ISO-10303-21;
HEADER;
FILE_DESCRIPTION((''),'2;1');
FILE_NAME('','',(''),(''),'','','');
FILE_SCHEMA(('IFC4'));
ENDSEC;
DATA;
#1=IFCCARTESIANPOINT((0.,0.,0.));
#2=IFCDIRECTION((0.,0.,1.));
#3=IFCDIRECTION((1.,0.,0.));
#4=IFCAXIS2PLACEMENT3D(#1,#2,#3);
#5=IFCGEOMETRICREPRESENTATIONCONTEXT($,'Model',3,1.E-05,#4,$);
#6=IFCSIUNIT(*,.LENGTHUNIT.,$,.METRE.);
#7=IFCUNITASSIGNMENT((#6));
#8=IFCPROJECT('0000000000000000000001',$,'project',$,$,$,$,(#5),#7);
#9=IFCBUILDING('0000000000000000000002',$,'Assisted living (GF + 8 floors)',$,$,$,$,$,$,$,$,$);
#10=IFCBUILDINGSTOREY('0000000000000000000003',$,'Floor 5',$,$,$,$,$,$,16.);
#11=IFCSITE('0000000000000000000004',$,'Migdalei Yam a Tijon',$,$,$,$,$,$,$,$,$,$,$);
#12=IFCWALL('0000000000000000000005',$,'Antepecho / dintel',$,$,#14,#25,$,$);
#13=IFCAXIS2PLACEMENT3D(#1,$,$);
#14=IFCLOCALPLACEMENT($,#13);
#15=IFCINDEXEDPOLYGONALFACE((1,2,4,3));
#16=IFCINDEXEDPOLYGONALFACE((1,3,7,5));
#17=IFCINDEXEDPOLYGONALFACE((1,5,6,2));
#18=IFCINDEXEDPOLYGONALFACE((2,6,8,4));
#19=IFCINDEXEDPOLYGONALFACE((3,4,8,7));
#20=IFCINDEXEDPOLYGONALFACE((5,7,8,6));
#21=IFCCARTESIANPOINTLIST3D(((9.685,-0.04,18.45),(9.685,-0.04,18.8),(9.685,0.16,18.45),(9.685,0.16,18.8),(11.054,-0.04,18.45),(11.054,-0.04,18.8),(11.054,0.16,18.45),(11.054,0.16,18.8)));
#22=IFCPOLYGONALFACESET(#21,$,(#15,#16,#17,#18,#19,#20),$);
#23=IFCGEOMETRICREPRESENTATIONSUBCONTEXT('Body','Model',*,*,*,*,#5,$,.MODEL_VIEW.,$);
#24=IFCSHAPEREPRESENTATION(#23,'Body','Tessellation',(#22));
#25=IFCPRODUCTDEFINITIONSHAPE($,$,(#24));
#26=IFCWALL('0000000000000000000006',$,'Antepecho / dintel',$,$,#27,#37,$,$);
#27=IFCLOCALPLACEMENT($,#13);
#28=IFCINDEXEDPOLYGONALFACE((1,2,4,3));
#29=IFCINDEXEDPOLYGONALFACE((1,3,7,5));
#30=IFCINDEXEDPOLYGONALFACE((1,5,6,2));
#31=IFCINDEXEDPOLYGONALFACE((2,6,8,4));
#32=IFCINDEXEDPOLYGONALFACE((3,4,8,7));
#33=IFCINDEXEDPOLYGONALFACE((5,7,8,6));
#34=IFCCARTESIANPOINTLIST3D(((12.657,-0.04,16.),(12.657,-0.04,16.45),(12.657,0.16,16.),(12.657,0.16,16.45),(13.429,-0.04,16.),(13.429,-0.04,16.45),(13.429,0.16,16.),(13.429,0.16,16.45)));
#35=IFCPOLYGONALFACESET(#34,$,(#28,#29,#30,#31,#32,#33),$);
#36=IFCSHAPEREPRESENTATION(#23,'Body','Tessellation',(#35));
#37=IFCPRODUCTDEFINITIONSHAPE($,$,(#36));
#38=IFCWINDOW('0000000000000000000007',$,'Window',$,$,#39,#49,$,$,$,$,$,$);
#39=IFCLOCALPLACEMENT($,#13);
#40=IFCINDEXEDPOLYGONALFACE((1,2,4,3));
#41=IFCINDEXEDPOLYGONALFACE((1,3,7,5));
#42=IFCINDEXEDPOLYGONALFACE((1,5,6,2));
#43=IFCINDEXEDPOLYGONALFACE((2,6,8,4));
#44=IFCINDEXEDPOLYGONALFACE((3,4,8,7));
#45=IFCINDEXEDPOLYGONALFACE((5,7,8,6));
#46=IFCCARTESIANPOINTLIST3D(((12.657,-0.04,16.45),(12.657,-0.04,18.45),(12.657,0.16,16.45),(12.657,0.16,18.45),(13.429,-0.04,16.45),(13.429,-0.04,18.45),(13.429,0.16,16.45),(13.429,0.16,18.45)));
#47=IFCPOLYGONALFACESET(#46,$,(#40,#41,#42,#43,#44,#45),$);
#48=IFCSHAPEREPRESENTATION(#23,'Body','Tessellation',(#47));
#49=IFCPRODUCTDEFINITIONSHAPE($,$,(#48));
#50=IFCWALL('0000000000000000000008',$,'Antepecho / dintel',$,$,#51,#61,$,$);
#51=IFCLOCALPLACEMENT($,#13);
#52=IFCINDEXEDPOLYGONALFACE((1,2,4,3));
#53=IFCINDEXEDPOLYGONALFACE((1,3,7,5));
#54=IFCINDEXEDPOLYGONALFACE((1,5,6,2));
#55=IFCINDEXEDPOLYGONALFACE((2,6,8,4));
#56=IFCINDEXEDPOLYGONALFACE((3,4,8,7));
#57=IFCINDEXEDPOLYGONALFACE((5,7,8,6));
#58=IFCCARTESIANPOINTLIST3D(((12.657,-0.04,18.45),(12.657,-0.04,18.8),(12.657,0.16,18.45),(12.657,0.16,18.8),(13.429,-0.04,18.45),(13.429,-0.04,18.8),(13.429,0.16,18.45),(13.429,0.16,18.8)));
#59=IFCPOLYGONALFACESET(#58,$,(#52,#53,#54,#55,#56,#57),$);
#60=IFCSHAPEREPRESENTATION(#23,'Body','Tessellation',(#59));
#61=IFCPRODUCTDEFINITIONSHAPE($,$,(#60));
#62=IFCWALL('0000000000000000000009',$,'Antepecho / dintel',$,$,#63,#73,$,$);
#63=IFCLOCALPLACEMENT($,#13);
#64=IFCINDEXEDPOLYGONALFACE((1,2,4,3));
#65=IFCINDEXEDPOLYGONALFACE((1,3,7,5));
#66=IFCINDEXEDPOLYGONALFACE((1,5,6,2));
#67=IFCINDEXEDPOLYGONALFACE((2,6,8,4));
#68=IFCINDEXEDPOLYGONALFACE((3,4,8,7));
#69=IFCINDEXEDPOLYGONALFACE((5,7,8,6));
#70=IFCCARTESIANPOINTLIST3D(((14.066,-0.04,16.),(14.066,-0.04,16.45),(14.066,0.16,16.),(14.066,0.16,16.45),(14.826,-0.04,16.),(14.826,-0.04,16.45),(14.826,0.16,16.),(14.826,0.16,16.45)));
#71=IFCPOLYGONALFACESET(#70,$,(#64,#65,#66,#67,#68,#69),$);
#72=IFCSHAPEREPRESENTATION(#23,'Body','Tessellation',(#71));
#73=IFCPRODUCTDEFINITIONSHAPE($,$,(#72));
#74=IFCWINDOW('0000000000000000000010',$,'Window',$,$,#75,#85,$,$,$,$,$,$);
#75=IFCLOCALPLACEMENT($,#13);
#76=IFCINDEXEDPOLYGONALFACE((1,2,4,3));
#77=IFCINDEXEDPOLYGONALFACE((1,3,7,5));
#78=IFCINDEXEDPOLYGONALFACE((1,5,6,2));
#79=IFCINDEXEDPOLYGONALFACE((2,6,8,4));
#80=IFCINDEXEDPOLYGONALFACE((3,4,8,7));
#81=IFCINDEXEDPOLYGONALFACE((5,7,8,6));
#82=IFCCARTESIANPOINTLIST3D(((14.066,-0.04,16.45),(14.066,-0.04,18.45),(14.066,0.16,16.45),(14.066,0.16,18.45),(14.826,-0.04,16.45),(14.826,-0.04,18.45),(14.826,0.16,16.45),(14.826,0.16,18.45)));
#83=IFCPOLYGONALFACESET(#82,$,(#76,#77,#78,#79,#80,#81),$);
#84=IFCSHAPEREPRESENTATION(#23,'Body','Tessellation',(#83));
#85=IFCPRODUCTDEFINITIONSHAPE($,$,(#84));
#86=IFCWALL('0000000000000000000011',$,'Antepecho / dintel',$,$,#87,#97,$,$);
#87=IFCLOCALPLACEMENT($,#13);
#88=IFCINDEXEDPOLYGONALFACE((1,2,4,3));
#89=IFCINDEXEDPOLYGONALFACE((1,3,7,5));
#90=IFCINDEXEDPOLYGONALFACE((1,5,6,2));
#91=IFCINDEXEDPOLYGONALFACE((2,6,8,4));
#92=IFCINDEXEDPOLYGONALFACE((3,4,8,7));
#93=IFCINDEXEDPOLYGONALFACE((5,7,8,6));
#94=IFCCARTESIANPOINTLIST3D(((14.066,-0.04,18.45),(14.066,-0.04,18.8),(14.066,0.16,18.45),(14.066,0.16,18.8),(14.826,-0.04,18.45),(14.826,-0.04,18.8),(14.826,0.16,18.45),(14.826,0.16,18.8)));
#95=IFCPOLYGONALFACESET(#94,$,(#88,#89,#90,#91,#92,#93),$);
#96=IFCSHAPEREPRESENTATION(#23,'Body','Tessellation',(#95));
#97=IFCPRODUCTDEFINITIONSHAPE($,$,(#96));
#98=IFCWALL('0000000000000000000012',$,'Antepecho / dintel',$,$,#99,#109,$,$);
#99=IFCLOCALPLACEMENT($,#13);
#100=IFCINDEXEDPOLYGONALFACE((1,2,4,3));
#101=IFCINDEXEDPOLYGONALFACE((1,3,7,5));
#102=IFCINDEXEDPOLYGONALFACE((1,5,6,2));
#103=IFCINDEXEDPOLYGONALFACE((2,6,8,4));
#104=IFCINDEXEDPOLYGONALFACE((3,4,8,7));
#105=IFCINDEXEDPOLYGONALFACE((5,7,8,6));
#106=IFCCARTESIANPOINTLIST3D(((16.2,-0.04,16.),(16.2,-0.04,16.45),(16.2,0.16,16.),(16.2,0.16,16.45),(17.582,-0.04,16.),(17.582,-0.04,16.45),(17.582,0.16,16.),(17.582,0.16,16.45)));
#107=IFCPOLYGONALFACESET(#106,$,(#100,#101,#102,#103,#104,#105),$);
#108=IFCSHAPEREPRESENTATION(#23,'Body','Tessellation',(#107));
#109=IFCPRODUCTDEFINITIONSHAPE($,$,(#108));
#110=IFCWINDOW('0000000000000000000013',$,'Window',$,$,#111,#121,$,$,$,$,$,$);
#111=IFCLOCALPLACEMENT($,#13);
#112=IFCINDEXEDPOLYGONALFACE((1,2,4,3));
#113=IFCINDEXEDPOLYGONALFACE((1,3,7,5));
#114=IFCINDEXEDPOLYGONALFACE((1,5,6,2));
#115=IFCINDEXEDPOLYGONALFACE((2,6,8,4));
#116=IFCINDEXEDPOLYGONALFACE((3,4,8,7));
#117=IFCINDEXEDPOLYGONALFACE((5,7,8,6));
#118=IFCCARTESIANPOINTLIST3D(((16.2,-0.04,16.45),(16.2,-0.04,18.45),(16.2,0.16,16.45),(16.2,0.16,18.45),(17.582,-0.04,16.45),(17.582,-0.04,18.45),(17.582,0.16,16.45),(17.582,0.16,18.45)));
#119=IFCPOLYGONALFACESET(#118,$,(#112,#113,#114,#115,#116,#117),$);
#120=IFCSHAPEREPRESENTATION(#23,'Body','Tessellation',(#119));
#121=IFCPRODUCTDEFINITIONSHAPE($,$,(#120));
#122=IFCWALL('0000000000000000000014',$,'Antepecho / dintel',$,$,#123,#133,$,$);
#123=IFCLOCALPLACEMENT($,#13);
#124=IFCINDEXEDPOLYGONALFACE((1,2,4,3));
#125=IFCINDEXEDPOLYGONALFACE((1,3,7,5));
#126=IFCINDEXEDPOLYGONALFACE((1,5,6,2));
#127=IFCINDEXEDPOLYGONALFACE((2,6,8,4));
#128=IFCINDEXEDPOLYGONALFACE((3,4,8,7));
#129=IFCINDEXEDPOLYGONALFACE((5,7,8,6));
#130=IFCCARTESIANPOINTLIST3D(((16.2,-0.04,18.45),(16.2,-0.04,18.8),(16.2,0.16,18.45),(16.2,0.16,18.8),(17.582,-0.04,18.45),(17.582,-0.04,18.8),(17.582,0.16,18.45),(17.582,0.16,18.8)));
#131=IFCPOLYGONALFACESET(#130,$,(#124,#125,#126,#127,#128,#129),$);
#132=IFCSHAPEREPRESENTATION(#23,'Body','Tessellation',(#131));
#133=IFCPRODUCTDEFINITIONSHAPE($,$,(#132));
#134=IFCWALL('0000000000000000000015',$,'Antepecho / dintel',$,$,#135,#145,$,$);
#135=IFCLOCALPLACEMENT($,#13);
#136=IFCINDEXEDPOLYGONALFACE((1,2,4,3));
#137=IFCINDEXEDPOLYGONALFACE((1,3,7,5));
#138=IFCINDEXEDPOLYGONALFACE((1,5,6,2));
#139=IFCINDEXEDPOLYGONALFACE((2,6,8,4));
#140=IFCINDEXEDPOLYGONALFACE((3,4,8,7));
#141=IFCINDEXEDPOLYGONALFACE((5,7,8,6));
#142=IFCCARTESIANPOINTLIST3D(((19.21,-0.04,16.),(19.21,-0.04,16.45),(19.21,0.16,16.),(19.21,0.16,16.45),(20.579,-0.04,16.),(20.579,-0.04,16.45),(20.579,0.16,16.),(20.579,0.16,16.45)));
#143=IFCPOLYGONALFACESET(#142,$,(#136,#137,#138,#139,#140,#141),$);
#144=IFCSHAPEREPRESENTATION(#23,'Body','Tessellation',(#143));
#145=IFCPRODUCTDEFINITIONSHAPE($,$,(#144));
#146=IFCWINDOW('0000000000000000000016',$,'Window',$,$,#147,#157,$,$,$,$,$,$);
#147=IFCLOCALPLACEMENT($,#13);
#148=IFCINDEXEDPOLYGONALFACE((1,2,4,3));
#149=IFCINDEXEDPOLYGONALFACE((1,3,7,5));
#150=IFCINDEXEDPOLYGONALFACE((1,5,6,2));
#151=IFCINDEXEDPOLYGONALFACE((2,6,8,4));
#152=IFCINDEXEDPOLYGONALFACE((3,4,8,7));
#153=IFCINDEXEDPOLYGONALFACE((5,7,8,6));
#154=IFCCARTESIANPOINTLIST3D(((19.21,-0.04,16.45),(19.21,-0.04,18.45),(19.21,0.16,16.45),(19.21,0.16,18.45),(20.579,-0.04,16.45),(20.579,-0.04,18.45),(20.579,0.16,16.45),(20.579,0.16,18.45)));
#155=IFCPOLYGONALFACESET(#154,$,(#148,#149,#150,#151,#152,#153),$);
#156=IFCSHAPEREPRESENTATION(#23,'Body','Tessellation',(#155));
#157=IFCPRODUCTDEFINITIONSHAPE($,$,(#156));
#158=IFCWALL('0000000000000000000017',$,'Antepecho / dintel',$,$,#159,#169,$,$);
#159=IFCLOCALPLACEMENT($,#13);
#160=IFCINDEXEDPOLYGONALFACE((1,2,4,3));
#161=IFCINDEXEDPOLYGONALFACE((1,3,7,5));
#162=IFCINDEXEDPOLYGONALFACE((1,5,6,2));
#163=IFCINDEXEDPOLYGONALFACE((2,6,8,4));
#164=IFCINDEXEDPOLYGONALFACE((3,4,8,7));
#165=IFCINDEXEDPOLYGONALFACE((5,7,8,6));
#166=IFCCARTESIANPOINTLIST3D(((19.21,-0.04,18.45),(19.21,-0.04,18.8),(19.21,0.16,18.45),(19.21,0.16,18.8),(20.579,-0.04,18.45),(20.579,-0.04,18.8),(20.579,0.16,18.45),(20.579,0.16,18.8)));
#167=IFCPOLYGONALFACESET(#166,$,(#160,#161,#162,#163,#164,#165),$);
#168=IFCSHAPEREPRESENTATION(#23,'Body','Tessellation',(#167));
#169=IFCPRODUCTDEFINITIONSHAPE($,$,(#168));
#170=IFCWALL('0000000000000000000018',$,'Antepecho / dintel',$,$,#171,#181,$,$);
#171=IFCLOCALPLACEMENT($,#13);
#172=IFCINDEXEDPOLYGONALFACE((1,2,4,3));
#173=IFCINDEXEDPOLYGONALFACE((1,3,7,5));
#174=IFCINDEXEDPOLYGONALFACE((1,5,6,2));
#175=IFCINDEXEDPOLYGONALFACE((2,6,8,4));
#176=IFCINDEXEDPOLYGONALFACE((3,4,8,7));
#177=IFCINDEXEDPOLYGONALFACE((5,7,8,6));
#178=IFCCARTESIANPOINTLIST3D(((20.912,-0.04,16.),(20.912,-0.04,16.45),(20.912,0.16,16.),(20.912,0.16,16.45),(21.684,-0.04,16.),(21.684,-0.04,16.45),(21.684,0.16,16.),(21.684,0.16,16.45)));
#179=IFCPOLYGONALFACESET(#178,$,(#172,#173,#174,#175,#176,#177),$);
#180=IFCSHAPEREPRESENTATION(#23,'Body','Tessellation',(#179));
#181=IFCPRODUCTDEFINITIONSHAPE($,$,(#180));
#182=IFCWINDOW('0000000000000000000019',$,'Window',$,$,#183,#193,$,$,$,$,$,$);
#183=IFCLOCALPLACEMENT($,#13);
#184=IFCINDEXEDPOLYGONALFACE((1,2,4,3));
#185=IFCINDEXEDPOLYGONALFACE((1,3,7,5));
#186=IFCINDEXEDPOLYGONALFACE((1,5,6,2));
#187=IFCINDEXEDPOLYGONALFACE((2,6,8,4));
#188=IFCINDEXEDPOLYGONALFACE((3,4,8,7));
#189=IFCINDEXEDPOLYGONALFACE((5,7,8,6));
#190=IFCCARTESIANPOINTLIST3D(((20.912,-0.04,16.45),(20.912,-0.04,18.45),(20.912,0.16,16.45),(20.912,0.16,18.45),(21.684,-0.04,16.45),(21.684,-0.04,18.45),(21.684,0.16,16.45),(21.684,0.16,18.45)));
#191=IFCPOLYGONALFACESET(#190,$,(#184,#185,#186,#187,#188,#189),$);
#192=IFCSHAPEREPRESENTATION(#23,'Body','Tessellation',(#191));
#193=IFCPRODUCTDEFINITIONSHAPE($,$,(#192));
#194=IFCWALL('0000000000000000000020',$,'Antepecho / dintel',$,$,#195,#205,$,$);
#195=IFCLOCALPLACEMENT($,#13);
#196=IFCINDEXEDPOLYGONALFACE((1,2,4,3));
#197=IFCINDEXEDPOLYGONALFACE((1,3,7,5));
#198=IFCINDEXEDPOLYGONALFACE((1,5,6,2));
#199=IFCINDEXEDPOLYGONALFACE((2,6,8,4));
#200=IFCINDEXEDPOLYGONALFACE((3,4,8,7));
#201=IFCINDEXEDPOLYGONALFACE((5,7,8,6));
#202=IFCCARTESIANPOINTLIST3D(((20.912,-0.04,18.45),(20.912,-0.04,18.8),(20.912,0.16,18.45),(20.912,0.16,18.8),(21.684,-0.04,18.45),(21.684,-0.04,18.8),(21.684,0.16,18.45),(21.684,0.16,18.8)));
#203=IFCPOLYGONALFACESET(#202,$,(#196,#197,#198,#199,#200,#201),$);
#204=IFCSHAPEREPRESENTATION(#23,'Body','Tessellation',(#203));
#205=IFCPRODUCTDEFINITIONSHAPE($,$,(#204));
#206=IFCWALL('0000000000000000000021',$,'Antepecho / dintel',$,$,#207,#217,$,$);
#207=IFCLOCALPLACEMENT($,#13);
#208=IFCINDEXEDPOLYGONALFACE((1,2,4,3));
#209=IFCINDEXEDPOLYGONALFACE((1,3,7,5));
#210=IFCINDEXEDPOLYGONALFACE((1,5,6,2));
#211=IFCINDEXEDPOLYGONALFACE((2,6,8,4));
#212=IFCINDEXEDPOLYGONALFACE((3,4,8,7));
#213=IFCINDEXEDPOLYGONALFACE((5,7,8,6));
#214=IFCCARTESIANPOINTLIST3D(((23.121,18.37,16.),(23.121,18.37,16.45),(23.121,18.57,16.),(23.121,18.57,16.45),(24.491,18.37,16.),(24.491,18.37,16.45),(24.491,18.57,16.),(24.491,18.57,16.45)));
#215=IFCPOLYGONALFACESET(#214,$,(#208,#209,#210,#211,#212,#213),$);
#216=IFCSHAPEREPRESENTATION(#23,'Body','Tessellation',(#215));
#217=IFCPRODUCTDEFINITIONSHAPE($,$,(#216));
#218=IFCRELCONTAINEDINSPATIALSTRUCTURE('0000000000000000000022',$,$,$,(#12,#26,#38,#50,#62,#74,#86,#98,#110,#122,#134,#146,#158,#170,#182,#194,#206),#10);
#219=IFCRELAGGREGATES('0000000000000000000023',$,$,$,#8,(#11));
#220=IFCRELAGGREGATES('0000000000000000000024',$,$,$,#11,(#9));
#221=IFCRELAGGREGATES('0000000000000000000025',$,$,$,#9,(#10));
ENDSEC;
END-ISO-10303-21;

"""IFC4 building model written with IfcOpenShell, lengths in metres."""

from ifc_helpers import new_model, si_unit, frame, origin_with_axes, context, subcontext, project, spatial, line, indexed_curve, outline, extrude, element, save


model = new_model("IFC4")

# Units and contexts
model_context = context("Model", 3, precision=1e-05, world=origin_with_axes())
body_context = subcontext(model_context, "Body", "Model", "MODEL_VIEW")
ifc_project = project(units=[si_unit("LENGTHUNIT", "METRE")], contexts=[model_context])

# Site, building, storey
site = spatial("IfcSite", under=ifc_project, Name="Migdalei Yam a Tijon")
building = spatial("IfcBuilding", under=site, Name="Assisted living (GF + 8 floors)")
storey = spatial("IfcBuildingStorey", under=building, Name="Floor 5", Elevation=16.0)

# Walls
element("IfcWall", 1, inside=storey, Name="Antepecho / dintel", context=body_context, shape_type="SweptSolid", body=[
    extrude(outline(indexed_curve([(0.0, 0.0), (1.369, 0.0), (1.369, 0.2), (0.0, 0.2)], segments=[line(1, 2, 3, 4, 1)])), frame((9.685, -0.04, 18.45), z_axis=(0.0, 0.0, 1.0), x_axis=(1.0, 0.0, 0.0)), (0.0, 0.0, 1.0), 0.35),
])
element("IfcWall", 2, inside=storey, Name="Antepecho / dintel", context=body_context, shape_type="SweptSolid", body=[
    extrude(outline(indexed_curve([(0.0, 0.0), (0.772, 0.0), (0.772, 0.2), (0.0, 0.2)], segments=[line(1, 2, 3, 4, 1)])), frame((12.657, -0.04, 16.0), z_axis=(0.0, 0.0, 1.0), x_axis=(1.0, 0.0, 0.0)), (0.0, 0.0, 1.0), 0.45),
])

# Window
element("IfcWindow", 3, inside=storey, Name="Window", context=body_context, shape_type="SweptSolid", body=[
    extrude(outline(indexed_curve([(0.0, 0.0), (0.772, 0.0), (0.772, 0.2), (0.0, 0.2)], segments=[line(1, 2, 3, 4, 1)])), frame((12.657, -0.04, 16.45), z_axis=(0.0, 0.0, 1.0), x_axis=(1.0, 0.0, 0.0)), (0.0, 0.0, 1.0), 2.0),
])

# Walls
element("IfcWall", 4, inside=storey, Name="Antepecho / dintel", context=body_context, shape_type="SweptSolid", body=[
    extrude(outline(indexed_curve([(0.0, 0.0), (0.772, 0.0), (0.772, 0.2), (0.0, 0.2)], segments=[line(1, 2, 3, 4, 1)])), frame((12.657, -0.04, 18.45), z_axis=(0.0, 0.0, 1.0), x_axis=(1.0, 0.0, 0.0)), (0.0, 0.0, 1.0), 0.35),
])
element("IfcWall", 5, inside=storey, Name="Antepecho / dintel", context=body_context, shape_type="SweptSolid", body=[
    extrude(outline(indexed_curve([(0.0, 0.0), (0.76, 0.0), (0.76, 0.2), (0.0, 0.2)], segments=[line(1, 2, 3, 4, 1)])), frame((14.066, -0.04, 16.0), z_axis=(0.0, 0.0, 1.0), x_axis=(1.0, 0.0, 0.0)), (0.0, 0.0, 1.0), 0.45),
])

# Window
element("IfcWindow", 6, inside=storey, Name="Window", context=body_context, shape_type="SweptSolid", body=[
    extrude(outline(indexed_curve([(0.0, 0.0), (0.76, 0.0), (0.76, 0.2), (0.0, 0.2)], segments=[line(1, 2, 3, 4, 1)])), frame((14.066, -0.04, 16.45), z_axis=(0.0, 0.0, 1.0), x_axis=(1.0, 0.0, 0.0)), (0.0, 0.0, 1.0), 2.0),
])

# Walls
element("IfcWall", 7, inside=storey, Name="Antepecho / dintel", context=body_context, shape_type="SweptSolid", body=[
    extrude(outline(indexed_curve([(0.0, 0.0), (0.76, 0.0), (0.76, 0.2), (0.0, 0.2)], segments=[line(1, 2, 3, 4, 1)])), frame((14.066, -0.04, 18.45), z_axis=(0.0, 0.0, 1.0), x_axis=(1.0, 0.0, 0.0)), (0.0, 0.0, 1.0), 0.35),
])
element("IfcWall", 8, inside=storey, Name="Antepecho / dintel", context=body_context, shape_type="SweptSolid", body=[
    extrude(outline(indexed_curve([(0.0, 0.0), (1.382, 0.0), (1.382, 0.2), (0.0, 0.2)], segments=[line(1, 2, 3, 4, 1)])), frame((16.2, -0.04, 16.0), z_axis=(0.0, 0.0, 1.0), x_axis=(1.0, 0.0, 0.0)), (0.0, 0.0, 1.0), 0.45),
])

# Window
element("IfcWindow", 9, inside=storey, Name="Window", context=body_context, shape_type="SweptSolid", body=[
    extrude(outline(indexed_curve([(0.0, 0.0), (1.382, 0.0), (1.382, 0.2), (0.0, 0.2)], segments=[line(1, 2, 3, 4, 1)])), frame((16.2, -0.04, 16.45), z_axis=(0.0, 0.0, 1.0), x_axis=(1.0, 0.0, 0.0)), (0.0, 0.0, 1.0), 2.0),
])

# Walls
element("IfcWall", 10, inside=storey, Name="Antepecho / dintel", context=body_context, shape_type="SweptSolid", body=[
    extrude(outline(indexed_curve([(0.0, 0.0), (1.382, 0.0), (1.382, 0.2), (0.0, 0.2)], segments=[line(1, 2, 3, 4, 1)])), frame((16.2, -0.04, 18.45), z_axis=(0.0, 0.0, 1.0), x_axis=(1.0, 0.0, 0.0)), (0.0, 0.0, 1.0), 0.35),
])
element("IfcWall", 11, inside=storey, Name="Antepecho / dintel", context=body_context, shape_type="SweptSolid", body=[
    extrude(outline(indexed_curve([(0.0, 0.0), (1.369, 0.0), (1.369, 0.2), (0.0, 0.2)], segments=[line(1, 2, 3, 4, 1)])), frame((19.21, -0.04, 16.0), z_axis=(0.0, 0.0, 1.0), x_axis=(1.0, 0.0, 0.0)), (0.0, 0.0, 1.0), 0.45),
])

# Window
element("IfcWindow", 12, inside=storey, Name="Window", context=body_context, shape_type="SweptSolid", body=[
    extrude(outline(indexed_curve([(0.0, 0.0), (1.369, 0.0), (1.369, 0.2), (0.0, 0.2)], segments=[line(1, 2, 3, 4, 1)])), frame((19.21, -0.04, 16.45), z_axis=(0.0, 0.0, 1.0), x_axis=(1.0, 0.0, 0.0)), (0.0, 0.0, 1.0), 2.0),
])

# Walls
element("IfcWall", 13, inside=storey, Name="Antepecho / dintel", context=body_context, shape_type="SweptSolid", body=[
    extrude(outline(indexed_curve([(0.0, 0.0), (1.369, 0.0), (1.369, 0.2), (0.0, 0.2)], segments=[line(1, 2, 3, 4, 1)])), frame((19.21, -0.04, 18.45), z_axis=(0.0, 0.0, 1.0), x_axis=(1.0, 0.0, 0.0)), (0.0, 0.0, 1.0), 0.35),
])
element("IfcWall", 14, inside=storey, Name="Antepecho / dintel", context=body_context, shape_type="SweptSolid", body=[
    extrude(outline(indexed_curve([(0.0, 0.0), (0.772, 0.0), (0.772, 0.2), (0.0, 0.2)], segments=[line(1, 2, 3, 4, 1)])), frame((20.912, -0.04, 16.0), z_axis=(0.0, 0.0, 1.0), x_axis=(1.0, 0.0, 0.0)), (0.0, 0.0, 1.0), 0.45),
])

# Window
element("IfcWindow", 15, inside=storey, Name="Window", context=body_context, shape_type="SweptSolid", body=[
    extrude(outline(indexed_curve([(0.0, 0.0), (0.772, 0.0), (0.772, 0.2), (0.0, 0.2)], segments=[line(1, 2, 3, 4, 1)])), frame((20.912, -0.04, 16.45), z_axis=(0.0, 0.0, 1.0), x_axis=(1.0, 0.0, 0.0)), (0.0, 0.0, 1.0), 2.0),
])

# Walls
element("IfcWall", 16, inside=storey, Name="Antepecho / dintel", context=body_context, shape_type="SweptSolid", body=[
    extrude(outline(indexed_curve([(0.0, 0.0), (0.772, 0.0), (0.772, 0.2), (0.0, 0.2)], segments=[line(1, 2, 3, 4, 1)])), frame((20.912, -0.04, 18.45), z_axis=(0.0, 0.0, 1.0), x_axis=(1.0, 0.0, 0.0)), (0.0, 0.0, 1.0), 0.35),
])
element("IfcWall", 17, inside=storey, Name="Antepecho / dintel", context=body_context, shape_type="SweptSolid", body=[
    extrude(outline(indexed_curve([(0.0, 0.0), (1.37, 0.0), (1.37, 0.2), (0.0, 0.2)], segments=[line(1, 2, 3, 4, 1)])), frame((23.121, 18.37, 16.0), z_axis=(0.0, 0.0, 1.0), x_axis=(1.0, 0.0, 0.0)), (0.0, 0.0, 1.0), 0.45),
])

save(model, "model.ifc")
